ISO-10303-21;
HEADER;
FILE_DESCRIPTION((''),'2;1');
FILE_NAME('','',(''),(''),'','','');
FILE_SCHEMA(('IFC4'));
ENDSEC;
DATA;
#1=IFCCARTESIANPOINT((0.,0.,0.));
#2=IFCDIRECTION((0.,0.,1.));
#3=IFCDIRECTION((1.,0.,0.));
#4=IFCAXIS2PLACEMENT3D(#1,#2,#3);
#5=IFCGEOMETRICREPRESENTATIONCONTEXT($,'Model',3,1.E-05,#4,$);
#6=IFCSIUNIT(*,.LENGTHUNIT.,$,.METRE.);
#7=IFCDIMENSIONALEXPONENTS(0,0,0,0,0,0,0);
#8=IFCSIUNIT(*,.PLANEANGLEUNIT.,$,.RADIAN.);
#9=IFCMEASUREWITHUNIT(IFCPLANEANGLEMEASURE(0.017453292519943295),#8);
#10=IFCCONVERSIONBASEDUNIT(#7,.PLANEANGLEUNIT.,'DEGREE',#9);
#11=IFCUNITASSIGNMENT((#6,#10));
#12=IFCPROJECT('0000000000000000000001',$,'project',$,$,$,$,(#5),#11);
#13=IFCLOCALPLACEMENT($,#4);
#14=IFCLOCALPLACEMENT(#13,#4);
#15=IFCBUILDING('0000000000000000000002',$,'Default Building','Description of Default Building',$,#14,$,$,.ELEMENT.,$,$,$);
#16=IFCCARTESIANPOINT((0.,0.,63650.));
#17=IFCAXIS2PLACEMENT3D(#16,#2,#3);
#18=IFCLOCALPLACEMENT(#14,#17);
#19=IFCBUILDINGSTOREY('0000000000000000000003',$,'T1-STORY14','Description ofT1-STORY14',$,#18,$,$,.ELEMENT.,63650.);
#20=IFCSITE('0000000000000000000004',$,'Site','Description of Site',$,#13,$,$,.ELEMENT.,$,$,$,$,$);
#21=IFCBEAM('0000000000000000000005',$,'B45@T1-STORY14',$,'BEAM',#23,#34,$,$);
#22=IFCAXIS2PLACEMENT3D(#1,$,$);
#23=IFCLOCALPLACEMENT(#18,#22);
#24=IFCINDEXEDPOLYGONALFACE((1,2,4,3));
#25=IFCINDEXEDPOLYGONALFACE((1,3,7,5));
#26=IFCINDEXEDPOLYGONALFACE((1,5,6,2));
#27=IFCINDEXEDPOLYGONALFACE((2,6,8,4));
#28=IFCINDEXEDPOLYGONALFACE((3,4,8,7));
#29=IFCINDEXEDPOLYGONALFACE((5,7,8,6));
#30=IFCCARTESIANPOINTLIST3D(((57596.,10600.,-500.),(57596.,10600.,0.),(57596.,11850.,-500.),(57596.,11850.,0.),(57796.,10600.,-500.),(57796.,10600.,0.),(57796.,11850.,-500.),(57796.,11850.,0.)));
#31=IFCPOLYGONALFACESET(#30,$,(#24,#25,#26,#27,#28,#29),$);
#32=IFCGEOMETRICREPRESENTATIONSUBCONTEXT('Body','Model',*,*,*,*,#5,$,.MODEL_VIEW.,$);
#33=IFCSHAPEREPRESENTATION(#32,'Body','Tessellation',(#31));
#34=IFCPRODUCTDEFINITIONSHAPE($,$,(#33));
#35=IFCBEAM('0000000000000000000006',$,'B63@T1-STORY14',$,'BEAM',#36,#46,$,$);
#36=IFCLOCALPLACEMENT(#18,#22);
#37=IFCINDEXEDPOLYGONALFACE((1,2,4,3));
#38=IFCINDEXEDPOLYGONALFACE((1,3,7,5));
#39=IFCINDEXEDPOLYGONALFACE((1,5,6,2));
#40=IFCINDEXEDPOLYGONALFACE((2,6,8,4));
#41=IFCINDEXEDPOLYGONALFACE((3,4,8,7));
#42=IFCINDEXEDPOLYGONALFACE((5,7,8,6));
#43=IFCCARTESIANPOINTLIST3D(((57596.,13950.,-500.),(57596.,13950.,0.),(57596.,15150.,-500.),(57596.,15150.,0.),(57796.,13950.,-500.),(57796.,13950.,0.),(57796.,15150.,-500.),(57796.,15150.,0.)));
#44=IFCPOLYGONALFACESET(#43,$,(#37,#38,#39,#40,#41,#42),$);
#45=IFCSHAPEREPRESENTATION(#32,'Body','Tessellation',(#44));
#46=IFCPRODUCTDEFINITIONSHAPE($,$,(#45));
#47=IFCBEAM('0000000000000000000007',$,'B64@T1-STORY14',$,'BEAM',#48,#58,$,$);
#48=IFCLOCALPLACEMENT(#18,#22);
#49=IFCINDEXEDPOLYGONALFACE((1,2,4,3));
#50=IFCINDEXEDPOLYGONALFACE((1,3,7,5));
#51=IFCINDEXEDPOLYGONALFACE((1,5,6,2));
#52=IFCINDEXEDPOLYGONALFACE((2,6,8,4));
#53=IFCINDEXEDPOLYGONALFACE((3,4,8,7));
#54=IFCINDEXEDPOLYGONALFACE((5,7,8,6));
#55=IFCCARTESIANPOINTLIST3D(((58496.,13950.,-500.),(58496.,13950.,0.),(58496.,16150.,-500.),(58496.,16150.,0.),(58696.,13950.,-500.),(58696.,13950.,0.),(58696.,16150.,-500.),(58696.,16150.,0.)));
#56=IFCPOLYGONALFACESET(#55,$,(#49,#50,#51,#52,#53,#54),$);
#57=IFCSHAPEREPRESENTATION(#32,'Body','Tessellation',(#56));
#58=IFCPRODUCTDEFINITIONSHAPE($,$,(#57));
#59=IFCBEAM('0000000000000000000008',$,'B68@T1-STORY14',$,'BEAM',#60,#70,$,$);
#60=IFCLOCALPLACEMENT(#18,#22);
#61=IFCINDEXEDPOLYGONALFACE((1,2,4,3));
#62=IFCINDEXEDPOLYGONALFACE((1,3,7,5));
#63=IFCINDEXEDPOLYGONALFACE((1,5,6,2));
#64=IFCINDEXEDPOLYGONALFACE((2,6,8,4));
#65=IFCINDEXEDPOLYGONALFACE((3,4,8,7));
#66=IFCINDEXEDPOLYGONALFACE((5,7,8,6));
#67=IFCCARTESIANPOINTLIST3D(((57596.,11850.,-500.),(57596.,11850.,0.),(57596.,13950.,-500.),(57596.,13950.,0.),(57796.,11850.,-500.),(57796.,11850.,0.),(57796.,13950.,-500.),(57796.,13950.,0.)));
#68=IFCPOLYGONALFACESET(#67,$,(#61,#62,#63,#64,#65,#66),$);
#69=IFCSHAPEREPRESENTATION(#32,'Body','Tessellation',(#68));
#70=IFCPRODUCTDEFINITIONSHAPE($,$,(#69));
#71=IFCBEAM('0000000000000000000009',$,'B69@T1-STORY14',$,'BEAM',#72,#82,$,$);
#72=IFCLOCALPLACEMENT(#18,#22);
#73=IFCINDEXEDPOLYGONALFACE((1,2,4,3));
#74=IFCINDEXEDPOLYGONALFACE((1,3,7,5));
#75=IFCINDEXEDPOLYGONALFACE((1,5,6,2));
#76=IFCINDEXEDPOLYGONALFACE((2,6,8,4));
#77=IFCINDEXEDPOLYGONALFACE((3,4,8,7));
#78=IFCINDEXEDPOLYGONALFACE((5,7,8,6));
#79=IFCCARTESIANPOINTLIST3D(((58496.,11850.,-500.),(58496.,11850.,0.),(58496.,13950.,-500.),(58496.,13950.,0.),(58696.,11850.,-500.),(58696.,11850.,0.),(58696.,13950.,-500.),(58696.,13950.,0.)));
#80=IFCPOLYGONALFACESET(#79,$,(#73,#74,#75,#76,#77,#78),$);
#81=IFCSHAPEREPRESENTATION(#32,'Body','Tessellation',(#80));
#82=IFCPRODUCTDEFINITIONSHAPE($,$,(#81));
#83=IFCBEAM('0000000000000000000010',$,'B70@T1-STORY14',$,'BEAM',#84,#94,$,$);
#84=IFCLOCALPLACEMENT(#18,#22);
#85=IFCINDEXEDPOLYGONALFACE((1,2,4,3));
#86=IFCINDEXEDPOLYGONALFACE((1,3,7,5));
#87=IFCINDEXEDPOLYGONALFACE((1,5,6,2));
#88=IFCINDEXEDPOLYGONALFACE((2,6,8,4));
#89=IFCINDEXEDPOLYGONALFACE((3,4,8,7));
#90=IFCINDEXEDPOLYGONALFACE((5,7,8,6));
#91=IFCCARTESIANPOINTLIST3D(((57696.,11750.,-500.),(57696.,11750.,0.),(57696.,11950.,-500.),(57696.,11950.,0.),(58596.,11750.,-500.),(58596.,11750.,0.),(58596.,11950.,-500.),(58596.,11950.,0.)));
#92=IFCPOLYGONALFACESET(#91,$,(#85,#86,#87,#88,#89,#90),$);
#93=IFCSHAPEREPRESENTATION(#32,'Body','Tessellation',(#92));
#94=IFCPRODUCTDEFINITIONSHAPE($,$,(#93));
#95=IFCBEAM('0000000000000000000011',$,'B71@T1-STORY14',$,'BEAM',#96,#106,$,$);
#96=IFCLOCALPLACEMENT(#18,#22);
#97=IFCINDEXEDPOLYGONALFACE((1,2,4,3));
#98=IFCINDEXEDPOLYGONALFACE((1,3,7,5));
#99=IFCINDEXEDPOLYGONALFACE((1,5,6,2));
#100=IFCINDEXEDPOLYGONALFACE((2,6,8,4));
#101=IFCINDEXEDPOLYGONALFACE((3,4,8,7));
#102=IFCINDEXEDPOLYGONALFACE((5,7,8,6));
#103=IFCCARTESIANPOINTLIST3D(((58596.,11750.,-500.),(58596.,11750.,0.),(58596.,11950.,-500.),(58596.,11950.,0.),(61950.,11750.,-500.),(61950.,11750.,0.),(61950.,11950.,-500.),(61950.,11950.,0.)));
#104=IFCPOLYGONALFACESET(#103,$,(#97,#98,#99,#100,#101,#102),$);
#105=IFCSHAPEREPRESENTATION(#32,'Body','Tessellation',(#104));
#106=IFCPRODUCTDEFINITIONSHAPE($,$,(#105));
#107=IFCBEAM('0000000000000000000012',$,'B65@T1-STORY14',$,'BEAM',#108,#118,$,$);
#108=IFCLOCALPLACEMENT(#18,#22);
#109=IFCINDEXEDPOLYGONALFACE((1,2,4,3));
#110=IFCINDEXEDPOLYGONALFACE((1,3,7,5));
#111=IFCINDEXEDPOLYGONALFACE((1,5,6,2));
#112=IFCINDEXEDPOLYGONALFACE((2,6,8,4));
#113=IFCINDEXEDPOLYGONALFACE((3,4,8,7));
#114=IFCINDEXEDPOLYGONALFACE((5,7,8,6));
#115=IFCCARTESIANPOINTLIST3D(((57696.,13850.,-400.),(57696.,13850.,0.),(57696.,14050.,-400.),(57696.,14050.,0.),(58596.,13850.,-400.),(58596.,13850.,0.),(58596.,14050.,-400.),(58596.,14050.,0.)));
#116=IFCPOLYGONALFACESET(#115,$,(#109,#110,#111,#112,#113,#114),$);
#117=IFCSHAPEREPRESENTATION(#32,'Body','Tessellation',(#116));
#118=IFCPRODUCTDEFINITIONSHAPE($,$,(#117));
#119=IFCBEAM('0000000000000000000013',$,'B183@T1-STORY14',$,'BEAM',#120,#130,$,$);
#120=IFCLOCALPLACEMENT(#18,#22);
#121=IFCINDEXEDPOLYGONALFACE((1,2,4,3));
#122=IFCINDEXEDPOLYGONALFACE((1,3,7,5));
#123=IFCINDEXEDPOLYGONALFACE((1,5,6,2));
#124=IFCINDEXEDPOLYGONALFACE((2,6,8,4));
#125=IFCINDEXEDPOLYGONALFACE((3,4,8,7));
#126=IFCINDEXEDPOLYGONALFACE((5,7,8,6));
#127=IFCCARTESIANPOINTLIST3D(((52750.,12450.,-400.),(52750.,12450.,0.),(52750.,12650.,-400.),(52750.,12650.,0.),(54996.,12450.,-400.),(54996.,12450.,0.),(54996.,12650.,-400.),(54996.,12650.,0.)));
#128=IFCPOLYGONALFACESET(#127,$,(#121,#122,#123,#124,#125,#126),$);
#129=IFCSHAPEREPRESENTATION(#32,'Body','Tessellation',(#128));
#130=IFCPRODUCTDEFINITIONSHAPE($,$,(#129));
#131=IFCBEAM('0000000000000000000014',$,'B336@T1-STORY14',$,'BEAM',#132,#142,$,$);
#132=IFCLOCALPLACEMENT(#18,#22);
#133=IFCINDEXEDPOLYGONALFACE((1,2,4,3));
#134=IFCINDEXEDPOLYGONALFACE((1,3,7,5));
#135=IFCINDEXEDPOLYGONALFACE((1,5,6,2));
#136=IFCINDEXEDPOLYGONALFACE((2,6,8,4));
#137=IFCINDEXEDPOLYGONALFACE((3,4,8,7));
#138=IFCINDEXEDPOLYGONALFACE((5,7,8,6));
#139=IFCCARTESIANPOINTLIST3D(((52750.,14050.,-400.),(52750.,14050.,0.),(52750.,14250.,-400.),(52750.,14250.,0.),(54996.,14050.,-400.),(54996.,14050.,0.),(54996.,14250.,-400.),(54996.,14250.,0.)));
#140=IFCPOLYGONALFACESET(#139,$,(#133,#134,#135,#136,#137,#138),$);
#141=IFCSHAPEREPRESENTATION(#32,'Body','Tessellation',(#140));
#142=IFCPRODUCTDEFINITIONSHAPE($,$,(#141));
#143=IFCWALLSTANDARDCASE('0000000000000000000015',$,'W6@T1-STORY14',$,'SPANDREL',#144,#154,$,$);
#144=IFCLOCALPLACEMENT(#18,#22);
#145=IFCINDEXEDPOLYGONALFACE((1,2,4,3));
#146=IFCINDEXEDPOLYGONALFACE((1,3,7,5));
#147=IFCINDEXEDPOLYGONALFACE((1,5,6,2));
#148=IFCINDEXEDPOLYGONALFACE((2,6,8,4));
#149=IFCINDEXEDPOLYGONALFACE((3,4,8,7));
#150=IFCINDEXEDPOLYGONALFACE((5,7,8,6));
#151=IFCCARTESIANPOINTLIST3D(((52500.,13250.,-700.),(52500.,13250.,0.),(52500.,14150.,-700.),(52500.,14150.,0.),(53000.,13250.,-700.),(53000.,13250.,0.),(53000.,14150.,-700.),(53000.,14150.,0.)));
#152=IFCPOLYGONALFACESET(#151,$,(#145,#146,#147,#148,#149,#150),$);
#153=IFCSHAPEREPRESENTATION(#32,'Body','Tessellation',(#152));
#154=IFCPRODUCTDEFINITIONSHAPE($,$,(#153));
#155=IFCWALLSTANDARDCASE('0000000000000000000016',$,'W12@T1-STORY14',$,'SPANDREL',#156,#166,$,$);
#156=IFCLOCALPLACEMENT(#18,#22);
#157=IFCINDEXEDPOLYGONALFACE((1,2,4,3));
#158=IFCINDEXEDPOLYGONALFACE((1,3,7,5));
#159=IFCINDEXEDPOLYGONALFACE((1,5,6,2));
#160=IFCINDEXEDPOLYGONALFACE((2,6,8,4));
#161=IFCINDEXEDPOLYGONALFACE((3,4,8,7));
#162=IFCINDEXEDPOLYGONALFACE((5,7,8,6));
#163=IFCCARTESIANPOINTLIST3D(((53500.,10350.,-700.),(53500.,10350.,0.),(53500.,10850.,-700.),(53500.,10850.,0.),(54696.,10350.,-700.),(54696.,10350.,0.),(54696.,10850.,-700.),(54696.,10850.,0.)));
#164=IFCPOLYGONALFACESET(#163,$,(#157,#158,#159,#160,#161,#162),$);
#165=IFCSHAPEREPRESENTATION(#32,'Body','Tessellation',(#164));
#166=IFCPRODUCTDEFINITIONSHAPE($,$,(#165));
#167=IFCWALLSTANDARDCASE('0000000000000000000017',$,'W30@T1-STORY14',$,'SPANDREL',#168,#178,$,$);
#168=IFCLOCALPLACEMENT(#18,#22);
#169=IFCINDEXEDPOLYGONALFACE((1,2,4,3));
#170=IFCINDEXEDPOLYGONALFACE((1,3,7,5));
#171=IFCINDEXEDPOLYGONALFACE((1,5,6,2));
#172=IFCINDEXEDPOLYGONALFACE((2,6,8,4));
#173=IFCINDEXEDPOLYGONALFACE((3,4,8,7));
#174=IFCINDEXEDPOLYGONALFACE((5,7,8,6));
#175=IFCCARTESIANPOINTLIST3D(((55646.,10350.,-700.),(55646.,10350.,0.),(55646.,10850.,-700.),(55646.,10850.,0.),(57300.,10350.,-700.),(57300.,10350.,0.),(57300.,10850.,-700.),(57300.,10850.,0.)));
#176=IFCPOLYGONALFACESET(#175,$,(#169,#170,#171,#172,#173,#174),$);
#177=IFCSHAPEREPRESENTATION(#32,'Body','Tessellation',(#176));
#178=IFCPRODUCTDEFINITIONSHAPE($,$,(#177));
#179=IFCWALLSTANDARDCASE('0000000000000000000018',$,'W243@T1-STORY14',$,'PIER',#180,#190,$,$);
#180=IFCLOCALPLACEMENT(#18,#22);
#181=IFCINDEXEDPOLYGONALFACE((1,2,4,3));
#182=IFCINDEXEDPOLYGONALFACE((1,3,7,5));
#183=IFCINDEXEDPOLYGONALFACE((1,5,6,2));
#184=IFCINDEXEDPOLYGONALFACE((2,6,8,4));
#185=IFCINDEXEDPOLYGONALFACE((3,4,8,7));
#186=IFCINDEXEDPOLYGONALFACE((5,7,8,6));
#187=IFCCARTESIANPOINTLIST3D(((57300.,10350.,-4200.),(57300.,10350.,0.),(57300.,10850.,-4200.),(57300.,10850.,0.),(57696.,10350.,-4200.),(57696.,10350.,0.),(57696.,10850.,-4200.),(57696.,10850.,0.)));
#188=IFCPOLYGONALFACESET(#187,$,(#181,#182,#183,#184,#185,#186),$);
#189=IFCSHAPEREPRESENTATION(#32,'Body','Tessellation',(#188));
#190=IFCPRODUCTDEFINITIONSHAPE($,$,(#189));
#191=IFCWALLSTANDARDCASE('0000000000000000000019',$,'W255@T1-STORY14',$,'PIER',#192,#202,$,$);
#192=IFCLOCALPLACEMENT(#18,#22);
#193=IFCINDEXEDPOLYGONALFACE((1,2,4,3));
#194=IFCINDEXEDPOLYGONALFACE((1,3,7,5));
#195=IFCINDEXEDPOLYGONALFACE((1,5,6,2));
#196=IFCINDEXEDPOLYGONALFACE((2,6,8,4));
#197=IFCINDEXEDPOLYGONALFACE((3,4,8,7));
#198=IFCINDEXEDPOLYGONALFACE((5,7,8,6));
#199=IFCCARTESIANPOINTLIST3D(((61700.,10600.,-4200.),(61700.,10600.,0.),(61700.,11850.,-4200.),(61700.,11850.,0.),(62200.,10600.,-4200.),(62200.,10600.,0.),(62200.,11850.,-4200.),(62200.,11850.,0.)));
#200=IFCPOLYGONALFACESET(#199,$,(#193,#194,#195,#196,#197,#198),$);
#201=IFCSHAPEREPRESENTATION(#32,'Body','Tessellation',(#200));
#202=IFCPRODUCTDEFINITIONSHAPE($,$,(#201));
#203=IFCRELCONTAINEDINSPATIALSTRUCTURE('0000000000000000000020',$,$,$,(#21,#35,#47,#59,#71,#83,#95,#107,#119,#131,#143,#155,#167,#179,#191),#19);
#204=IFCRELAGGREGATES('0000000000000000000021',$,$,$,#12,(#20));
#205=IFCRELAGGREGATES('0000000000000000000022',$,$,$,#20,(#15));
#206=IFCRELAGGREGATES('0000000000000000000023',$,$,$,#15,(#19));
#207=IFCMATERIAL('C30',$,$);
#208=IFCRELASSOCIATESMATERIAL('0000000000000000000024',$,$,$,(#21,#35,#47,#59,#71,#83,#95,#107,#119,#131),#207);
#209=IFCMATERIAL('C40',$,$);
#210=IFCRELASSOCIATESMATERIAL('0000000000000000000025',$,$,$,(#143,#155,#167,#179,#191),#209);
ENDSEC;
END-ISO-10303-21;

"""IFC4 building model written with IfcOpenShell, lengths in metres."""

from ifc_helpers import new_model, entity, si_unit, converted_unit, frame, origin_with_axes, place, context, subcontext, project, spatial, indexed_curve, rectangle, outline, extrude, material, element, save


model = new_model("IFC4")

# Units and contexts
model_context = context("Model", 3, precision=1e-05, world=origin_with_axes())
body_context = subcontext(model_context, "Body", "Model", "MODEL_VIEW")
ifc_project = project(units=[si_unit("LENGTHUNIT", "METRE"), converted_unit("PLANEANGLEUNIT", "DEGREE", entity("IfcPlaneAngleMeasure", 0.017453292519943295), si_unit("PLANEANGLEUNIT", "RADIAN"), dimensions=[0, 0, 0, 0, 0, 0, 0])], contexts=[model_context])

# Site, building, storey
site_placement = place(None, origin_with_axes())
site = spatial("IfcSite", under=ifc_project, at=site_placement, Name="Site", Description="Description of Site", CompositionType="ELEMENT")
building_placement = place(site_placement, origin_with_axes())
building = spatial("IfcBuilding", under=site, at=building_placement, Name="Default Building", Description="Description of Default Building", CompositionType="ELEMENT")
storey_placement = place(building_placement, frame((0.0, 0.0, 63650.0), z_axis=(0.0, 0.0, 1.0), x_axis=(1.0, 0.0, 0.0)))
storey = spatial("IfcBuildingStorey", under=building, at=storey_placement, Name="T1-STORY14", Description="Description ofT1-STORY14", CompositionType="ELEMENT", Elevation=63650.0)

# Beams
ifc_material_1 = material(Name="C30")
beam_1_placement = place(storey_placement, frame((57696.0, 10600.0, -250.0), z_axis=(0.0, 1.0, 0.0), x_axis=(-1.0, 0.0, 0.0)))
element("IfcBeam", 1, at=beam_1_placement, inside=storey, material=ifc_material_1, Name="B45@T1-STORY14", ObjectType="BEAM", context=body_context, shape_type="SweptSolid", body=[
    extrude(rectangle(XDim=200.0, YDim=500.0), origin_with_axes(), (0.0, 0.0, 1.0), 1250.0),
])
beam_2_placement = place(storey_placement, frame((57696.0, 13950.0, -250.0), z_axis=(0.0, 1.0, 0.0), x_axis=(-1.0, 0.0, 0.0)))
element("IfcBeam", 2, at=beam_2_placement, inside=storey, material=ifc_material_1, Name="B63@T1-STORY14", ObjectType="BEAM", context=body_context, shape_type="SweptSolid", body=[
    extrude(rectangle(XDim=200.0, YDim=500.0), origin_with_axes(), (0.0, 0.0, 1.0), 1200.0),
])
beam_3_placement = place(storey_placement, frame((58596.0, 13950.0, -250.0), z_axis=(0.0, 1.0, 0.0), x_axis=(-1.0, 0.0, 0.0)))
element("IfcBeam", 3, at=beam_3_placement, inside=storey, material=ifc_material_1, Name="B64@T1-STORY14", ObjectType="BEAM", context=body_context, shape_type="SweptSolid", body=[
    extrude(rectangle(XDim=200.0, YDim=500.0), origin_with_axes(), (0.0, 0.0, 1.0), 2200.0),
])
for number, where, z_axis, x_axis, name in (
    (4, (57696.0, 11850.0, -250.0), (0.0, 1.0, 0.0), (-1.0, 0.0, 0.0), "B68@T1-STORY14"),
    (5, (58596.0, 11850.0, -250.0), (0.0, 1.0, 0.0), (-1.0, 0.0, 0.0), "B69@T1-STORY14"),
):
    element("IfcBeam", number, at=place(storey_placement, frame(where, z_axis=z_axis, x_axis=x_axis)), inside=storey, material=ifc_material_1, Name=name, ObjectType="BEAM", context=body_context, shape_type="SweptSolid", body=[
        extrude(rectangle(XDim=200.0, YDim=500.0), origin_with_axes(), (0.0, 0.0, 1.0), 2100.0),
    ])
beam_4_placement = place(storey_placement, frame((57696.0, 11850.0, -250.0), z_axis=(1.0, 0.0, 0.0), x_axis=(0.0, 1.0, 0.0)))
element("IfcBeam", 6, at=beam_4_placement, inside=storey, material=ifc_material_1, Name="B70@T1-STORY14", ObjectType="BEAM", context=body_context, shape_type="SweptSolid", body=[
    extrude(rectangle(XDim=200.0, YDim=500.0), origin_with_axes(), (0.0, 0.0, 1.0), 900.0),
])
beam_5_placement = place(storey_placement, frame((58596.0, 11850.0, -250.0), z_axis=(1.0, 0.0, 0.0), x_axis=(0.0, 1.0, 0.0)))
element("IfcBeam", 7, at=beam_5_placement, inside=storey, material=ifc_material_1, Name="B71@T1-STORY14", ObjectType="BEAM", context=body_context, shape_type="SweptSolid", body=[
    extrude(rectangle(XDim=200.0, YDim=500.0), origin_with_axes(), (0.0, 0.0, 1.0), 3354.0),
])
beam_6_placement = place(storey_placement, frame((57696.0, 13950.0, -200.0), z_axis=(1.0, 0.0, 0.0), x_axis=(0.0, 1.0, 0.0)))
element("IfcBeam", 8, at=beam_6_placement, inside=storey, material=ifc_material_1, Name="B65@T1-STORY14", ObjectType="BEAM", context=body_context, shape_type="SweptSolid", body=[
    extrude(rectangle(XDim=200.0, YDim=400.0), origin_with_axes(), (0.0, 0.0, 1.0), 900.0),
])
for number, where, z_axis, x_axis, name in (
    (9, (52750.0, 12550.0, -200.0), (1.0, 0.0, 0.0), (0.0, 1.0, 0.0), "B183@T1-STORY14"),
    (10, (52750.0, 14150.0, -200.0), (1.0, 0.0, 0.0), (0.0, 1.0, 0.0), "B336@T1-STORY14"),
):
    element("IfcBeam", number, at=place(storey_placement, frame(where, z_axis=z_axis, x_axis=x_axis)), inside=storey, material=ifc_material_1, Name=name, ObjectType="BEAM", context=body_context, shape_type="SweptSolid", body=[
        extrude(rectangle(XDim=200.0, YDim=400.0), origin_with_axes(), (0.0, 0.0, 1.0), 2246.0),
    ])

# Walls
ifc_material_2 = material(Name="C40")
wall_1_placement = place(storey_placement, frame((52750.0, 13250.0, -700.0), z_axis=(0.0, 0.0, 1.0), x_axis=(0.0, 1.0, 0.0)))
element("IfcWallStandardCase", 11, at=wall_1_placement, inside=storey, material=ifc_material_2, Name="W6@T1-STORY14", ObjectType="SPANDREL", context=body_context, shape_type="SweptSolid", body=[
    extrude(outline(indexed_curve([(0.0, -250.0), (0.0, 250.0), (900.0, 250.0), (900.0, -250.0), (0.0, -250.0)], self_intersect=False)), origin_with_axes(), (0.0, 0.0, 1.0), 700.0),
])
wall_2_placement = place(storey_placement, frame((53500.0, 10600.0, -700.0), z_axis=(0.0, 0.0, 1.0), x_axis=(1.0, 0.0, 0.0)))
element("IfcWallStandardCase", 12, at=wall_2_placement, inside=storey, material=ifc_material_2, Name="W12@T1-STORY14", ObjectType="SPANDREL", context=body_context, shape_type="SweptSolid", body=[
    extrude(outline(indexed_curve([(0.0, -250.0), (0.0, 250.0), (1196.0, 250.0), (1196.0, -250.0), (0.0, -250.0)], self_intersect=False)), origin_with_axes(), (0.0, 0.0, 1.0), 700.0),
])
wall_3_placement = place(storey_placement, frame((55646.0, 10600.0, -700.0), z_axis=(0.0, 0.0, 1.0), x_axis=(1.0, 0.0, 0.0)))
element("IfcWallStandardCase", 13, at=wall_3_placement, inside=storey, material=ifc_material_2, Name="W30@T1-STORY14", ObjectType="SPANDREL", context=body_context, shape_type="SweptSolid", body=[
    extrude(outline(indexed_curve([(0.0, -250.0), (0.0, 250.0), (1654.0, 250.0), (1654.0, -250.0), (0.0, -250.0)], self_intersect=False)), origin_with_axes(), (0.0, 0.0, 1.0), 700.0),
])
wall_4_placement = place(storey_placement, frame((57300.0, 10600.0, -4200.0), z_axis=(0.0, 0.0, 1.0), x_axis=(1.0, 0.0, 0.0)))
element("IfcWallStandardCase", 14, at=wall_4_placement, inside=storey, material=ifc_material_2, Name="W243@T1-STORY14", ObjectType="PIER", context=body_context, shape_type="SweptSolid", body=[
    extrude(outline(indexed_curve([(0.0, -250.0), (0.0, 250.0), (396.0, 250.0), (396.0, -250.0), (0.0, -250.0)], self_intersect=False)), origin_with_axes(), (0.0, 0.0, 1.0), 4200.0),
])
wall_5_placement = place(storey_placement, frame((61950.0, 10600.0, -4200.0), z_axis=(0.0, 0.0, 1.0), x_axis=(0.0, 1.0, 0.0)))
element("IfcWallStandardCase", 15, at=wall_5_placement, inside=storey, material=ifc_material_2, Name="W255@T1-STORY14", ObjectType="PIER", context=body_context, shape_type="SweptSolid", body=[
    extrude(outline(indexed_curve([(0.0, -250.0), (0.0, 250.0), (1250.0, 250.0), (1250.0, -250.0), (0.0, -250.0)], self_intersect=False)), origin_with_axes(), (0.0, 0.0, 1.0), 4200.0),
])

save(model, "model.ifc")
